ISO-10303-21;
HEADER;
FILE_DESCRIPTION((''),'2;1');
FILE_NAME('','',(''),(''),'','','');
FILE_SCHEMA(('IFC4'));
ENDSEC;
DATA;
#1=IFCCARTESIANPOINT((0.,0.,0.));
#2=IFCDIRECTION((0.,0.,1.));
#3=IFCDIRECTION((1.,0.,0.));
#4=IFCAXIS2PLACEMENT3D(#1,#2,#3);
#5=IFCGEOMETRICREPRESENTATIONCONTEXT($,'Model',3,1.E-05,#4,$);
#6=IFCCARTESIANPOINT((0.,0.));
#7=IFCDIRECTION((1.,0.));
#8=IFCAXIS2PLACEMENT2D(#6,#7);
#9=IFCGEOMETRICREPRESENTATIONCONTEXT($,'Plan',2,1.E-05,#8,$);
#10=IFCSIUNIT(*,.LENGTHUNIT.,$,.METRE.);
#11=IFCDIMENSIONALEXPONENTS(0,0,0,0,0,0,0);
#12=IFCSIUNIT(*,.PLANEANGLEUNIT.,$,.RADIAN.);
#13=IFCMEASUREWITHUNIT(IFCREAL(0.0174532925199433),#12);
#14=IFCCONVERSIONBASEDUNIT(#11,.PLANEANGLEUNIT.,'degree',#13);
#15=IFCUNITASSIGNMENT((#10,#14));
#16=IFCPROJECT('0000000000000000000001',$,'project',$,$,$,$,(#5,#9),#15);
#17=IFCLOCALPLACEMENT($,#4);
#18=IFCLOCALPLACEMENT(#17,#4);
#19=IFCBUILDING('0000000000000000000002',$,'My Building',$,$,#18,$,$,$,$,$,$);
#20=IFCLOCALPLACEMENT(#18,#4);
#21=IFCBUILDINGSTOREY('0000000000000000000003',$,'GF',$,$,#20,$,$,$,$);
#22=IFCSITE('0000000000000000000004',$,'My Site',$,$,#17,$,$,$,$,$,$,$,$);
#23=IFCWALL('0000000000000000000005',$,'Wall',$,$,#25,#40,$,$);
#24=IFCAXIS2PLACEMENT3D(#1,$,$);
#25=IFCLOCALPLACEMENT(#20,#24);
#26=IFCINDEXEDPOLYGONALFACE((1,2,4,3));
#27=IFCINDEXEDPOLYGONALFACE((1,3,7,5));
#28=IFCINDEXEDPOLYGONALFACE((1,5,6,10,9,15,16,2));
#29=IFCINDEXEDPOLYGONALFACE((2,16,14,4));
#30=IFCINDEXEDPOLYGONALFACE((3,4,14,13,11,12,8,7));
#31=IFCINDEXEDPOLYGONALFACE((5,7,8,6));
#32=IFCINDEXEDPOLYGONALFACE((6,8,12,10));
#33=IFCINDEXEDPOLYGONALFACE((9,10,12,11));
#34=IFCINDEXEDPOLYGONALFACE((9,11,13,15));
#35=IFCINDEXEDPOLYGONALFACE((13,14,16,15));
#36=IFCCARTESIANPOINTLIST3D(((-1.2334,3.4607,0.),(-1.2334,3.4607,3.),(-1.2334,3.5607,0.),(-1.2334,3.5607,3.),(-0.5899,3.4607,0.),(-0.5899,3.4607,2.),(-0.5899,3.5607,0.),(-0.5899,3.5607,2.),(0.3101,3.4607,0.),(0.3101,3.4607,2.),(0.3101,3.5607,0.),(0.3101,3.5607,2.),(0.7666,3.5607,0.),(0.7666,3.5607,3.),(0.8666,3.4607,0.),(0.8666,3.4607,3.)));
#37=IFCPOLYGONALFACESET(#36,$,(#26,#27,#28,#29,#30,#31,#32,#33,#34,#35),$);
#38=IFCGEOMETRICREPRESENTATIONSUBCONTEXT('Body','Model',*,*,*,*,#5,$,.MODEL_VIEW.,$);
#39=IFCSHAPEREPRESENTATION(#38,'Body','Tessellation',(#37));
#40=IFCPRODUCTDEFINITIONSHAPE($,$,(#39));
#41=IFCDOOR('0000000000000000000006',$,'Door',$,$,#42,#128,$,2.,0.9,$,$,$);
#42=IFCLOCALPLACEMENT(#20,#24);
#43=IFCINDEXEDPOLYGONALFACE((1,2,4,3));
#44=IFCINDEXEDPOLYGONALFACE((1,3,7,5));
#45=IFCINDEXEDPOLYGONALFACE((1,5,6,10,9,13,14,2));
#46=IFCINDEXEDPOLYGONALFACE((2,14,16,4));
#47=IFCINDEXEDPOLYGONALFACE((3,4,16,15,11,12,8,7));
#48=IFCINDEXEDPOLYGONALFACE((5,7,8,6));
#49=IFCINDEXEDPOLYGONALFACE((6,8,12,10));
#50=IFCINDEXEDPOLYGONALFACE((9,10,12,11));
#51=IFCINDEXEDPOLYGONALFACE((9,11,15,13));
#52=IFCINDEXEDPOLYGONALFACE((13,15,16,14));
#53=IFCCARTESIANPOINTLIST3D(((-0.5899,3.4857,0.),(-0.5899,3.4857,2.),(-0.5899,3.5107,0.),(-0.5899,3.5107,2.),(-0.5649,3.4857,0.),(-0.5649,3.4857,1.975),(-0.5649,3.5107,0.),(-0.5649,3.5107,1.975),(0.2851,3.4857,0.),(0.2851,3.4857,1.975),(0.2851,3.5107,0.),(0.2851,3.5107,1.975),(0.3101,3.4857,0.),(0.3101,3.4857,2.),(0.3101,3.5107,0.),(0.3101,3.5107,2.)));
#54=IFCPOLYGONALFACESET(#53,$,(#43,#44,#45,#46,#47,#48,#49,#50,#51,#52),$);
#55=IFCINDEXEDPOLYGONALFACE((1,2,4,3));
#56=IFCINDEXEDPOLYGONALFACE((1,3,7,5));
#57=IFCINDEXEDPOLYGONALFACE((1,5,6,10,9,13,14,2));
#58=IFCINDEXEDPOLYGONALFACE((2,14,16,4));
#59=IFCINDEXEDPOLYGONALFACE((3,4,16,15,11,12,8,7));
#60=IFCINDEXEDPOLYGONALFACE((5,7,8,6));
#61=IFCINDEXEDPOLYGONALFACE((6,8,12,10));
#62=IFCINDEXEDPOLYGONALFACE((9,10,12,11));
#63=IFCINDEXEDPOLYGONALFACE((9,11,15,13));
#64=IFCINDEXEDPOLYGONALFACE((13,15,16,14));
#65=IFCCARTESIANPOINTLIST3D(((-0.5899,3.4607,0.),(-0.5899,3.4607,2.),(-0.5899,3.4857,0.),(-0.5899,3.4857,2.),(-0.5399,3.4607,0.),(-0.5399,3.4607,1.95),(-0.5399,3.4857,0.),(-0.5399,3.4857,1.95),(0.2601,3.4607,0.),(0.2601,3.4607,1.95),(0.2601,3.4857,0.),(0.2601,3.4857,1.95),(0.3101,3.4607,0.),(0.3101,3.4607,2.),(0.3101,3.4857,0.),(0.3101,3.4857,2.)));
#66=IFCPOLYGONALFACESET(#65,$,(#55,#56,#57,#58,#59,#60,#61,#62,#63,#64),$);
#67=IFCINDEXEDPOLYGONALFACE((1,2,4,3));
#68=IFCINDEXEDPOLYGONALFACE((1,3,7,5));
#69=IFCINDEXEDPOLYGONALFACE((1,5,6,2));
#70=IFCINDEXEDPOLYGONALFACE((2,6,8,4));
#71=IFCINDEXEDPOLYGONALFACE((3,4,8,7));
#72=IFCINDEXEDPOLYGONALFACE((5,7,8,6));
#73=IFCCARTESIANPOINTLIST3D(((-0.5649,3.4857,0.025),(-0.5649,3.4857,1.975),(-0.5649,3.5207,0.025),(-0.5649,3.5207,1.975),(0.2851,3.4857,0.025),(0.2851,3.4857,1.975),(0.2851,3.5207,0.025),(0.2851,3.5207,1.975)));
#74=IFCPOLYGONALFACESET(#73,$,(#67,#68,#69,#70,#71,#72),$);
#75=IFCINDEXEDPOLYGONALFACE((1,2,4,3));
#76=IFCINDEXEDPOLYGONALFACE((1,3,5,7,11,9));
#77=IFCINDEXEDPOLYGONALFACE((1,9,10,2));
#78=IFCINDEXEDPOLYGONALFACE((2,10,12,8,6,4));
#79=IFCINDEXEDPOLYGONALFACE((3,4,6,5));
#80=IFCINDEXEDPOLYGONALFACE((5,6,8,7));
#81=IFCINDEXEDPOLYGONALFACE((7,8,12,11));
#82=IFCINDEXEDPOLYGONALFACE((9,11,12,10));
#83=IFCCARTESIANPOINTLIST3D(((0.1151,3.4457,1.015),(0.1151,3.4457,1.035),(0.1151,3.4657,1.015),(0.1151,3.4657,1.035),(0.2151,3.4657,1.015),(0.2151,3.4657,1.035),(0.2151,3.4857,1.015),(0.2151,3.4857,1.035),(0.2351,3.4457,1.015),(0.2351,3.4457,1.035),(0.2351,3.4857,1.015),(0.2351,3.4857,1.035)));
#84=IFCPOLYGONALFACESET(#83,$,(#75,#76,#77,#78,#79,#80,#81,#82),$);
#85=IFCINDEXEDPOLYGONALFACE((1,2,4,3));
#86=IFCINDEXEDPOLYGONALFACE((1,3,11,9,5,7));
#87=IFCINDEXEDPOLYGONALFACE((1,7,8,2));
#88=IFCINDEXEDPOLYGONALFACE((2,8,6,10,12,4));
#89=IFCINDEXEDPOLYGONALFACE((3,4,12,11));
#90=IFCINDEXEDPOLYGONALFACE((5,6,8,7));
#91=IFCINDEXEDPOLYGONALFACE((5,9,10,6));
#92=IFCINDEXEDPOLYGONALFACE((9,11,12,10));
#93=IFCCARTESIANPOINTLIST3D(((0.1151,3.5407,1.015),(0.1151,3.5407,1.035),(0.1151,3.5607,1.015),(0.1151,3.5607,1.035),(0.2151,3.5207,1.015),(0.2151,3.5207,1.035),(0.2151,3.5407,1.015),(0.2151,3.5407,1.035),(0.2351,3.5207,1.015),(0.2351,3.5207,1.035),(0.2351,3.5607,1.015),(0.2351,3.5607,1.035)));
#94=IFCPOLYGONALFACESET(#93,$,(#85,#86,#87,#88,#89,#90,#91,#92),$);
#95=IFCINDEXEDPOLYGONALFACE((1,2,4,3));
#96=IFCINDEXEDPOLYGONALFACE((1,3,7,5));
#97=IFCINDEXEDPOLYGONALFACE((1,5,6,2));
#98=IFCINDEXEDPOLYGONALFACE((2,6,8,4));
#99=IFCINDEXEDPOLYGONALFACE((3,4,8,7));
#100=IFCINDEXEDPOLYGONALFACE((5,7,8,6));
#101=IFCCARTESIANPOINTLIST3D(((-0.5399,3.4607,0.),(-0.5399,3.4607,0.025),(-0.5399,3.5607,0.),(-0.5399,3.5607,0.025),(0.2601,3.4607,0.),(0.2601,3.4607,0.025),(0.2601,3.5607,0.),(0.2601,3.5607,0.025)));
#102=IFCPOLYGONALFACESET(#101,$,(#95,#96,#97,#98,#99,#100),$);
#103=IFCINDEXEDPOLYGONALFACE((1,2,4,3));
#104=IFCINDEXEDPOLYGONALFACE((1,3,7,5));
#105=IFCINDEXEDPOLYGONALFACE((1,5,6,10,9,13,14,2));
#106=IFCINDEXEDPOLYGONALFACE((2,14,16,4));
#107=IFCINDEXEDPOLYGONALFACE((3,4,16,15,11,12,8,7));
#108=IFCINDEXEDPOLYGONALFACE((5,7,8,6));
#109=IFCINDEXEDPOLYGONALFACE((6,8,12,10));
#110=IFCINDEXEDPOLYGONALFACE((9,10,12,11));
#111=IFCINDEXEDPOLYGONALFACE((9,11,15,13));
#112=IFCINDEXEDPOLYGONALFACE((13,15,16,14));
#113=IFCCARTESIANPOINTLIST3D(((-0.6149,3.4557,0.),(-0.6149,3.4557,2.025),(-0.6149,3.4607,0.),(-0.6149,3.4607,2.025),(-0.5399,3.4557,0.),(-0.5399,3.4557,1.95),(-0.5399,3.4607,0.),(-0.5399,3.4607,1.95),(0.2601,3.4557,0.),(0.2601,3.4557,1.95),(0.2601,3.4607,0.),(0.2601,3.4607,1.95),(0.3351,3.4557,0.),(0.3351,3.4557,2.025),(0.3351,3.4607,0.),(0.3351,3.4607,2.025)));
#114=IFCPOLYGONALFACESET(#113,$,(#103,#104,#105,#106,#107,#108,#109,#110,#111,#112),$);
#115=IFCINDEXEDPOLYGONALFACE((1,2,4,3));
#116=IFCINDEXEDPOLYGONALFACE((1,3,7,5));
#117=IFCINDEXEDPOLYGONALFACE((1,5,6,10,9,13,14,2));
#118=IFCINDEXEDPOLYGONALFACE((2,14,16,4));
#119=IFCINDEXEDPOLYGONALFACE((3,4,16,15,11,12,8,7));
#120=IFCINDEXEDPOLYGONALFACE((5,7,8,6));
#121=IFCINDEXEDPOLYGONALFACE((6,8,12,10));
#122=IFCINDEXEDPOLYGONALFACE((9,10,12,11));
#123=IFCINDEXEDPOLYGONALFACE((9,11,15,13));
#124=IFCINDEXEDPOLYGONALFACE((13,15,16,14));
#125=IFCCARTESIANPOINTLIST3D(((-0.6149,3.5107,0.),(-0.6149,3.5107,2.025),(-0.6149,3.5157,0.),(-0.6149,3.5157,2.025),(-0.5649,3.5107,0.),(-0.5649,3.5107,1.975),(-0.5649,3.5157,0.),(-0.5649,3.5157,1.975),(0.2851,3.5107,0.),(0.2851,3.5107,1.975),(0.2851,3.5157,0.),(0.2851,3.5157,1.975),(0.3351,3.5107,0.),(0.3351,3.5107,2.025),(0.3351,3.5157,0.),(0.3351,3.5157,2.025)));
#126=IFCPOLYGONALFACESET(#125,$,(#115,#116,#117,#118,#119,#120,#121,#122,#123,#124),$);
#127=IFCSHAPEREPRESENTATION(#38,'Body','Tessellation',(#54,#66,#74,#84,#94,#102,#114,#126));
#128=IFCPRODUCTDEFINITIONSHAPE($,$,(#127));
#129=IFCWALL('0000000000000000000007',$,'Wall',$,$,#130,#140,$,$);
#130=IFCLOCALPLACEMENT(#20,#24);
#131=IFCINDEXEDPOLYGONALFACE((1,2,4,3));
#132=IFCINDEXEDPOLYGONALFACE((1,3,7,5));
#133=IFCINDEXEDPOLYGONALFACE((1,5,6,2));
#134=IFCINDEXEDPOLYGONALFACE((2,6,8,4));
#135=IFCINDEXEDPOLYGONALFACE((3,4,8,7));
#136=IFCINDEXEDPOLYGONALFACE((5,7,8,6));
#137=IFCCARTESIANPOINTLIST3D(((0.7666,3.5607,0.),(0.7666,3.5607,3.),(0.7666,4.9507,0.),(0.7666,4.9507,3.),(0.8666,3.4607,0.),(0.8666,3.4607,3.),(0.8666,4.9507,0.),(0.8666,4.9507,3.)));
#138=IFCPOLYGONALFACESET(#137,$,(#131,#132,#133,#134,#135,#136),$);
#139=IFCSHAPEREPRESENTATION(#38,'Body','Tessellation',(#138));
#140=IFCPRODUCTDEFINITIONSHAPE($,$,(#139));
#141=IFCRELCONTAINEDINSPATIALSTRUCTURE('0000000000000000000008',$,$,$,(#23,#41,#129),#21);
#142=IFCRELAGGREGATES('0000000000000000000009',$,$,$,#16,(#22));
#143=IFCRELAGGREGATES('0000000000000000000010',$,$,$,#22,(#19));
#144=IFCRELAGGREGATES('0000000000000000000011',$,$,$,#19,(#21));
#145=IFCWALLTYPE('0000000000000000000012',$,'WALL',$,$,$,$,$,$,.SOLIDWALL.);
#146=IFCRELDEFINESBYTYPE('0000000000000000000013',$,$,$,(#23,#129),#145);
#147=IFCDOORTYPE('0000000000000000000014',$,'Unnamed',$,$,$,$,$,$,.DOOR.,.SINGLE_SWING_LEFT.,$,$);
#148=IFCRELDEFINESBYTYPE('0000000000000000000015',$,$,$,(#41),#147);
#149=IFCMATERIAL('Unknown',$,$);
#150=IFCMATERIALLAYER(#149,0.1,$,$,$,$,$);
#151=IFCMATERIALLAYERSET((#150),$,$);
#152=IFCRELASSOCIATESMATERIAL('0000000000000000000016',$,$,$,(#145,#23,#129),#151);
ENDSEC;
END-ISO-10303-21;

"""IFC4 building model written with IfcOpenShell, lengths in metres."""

from ifc_helpers import new_model, entity, si_unit, converted_unit, frame, origin_with_axes, origin_2d_with_axis, place, context, subcontext, project, spatial, line, indexed_curve, outline, extrude, shape, source, transform, mapped, material, layer, layer_set, layer_usage, type_object, type_shapes, element, fill, save


model = new_model("IFC4")

# Units and contexts
model_context = context("Model", 3, precision=1e-05, world=origin_with_axes())
plan_context = context("Plan", 2, precision=1e-05, world=origin_2d_with_axis())
body_context_1 = subcontext(model_context, "Body", "Model", "MODEL_VIEW")
body_context_2 = subcontext(plan_context, "Body", "Plan", "PLAN_VIEW")
ifc_project = project(units=[si_unit("LENGTHUNIT", "METRE"), converted_unit("PLANEANGLEUNIT", "degree", entity("IfcReal", 0.0174532925199433), si_unit("PLANEANGLEUNIT", "RADIAN"), dimensions=[0, 0, 0, 0, 0, 0, 0])], contexts=[model_context, plan_context])

# Site, building, storey
site_placement = place(None, origin_with_axes())
site = spatial("IfcSite", under=ifc_project, at=site_placement, Name="My Site")
building_placement = place(site_placement, origin_with_axes())
building = spatial("IfcBuilding", under=site, at=building_placement, Name="My Building")
storey_placement = place(building_placement, origin_with_axes())
storey = spatial("IfcBuildingStorey", under=building, at=storey_placement, Name="GF")

# Shared definitions
ifc_material = material(Name="Unknown")

# Shared definitions
ifc_layer = layer(ifc_material, 0.1)
ifc_layer_set = layer_set([ifc_layer])
wall_type = type_object("IfcWallType", Name="WALL", PredefinedType="SOLIDWALL", material=ifc_layer_set)

# Wall, opening, door
ifc_layer_usage_1 = layer_usage(ifc_layer_set, "AXIS2", "POSITIVE", 0.0)
wall_1_placement = place(storey_placement, frame((-1.2334, 3.4607, 0.0), z_axis=(0.0, 0.0, 1.0), x_axis=(1.0, 0.0, 0.0)))
wall_1 = element("IfcWall", 1, at=wall_1_placement, inside=storey, type_object=wall_type, material=ifc_layer_usage_1, Name="Wall", context=body_context_1, shape_type="SweptSolid", body=[
    extrude(outline(indexed_curve([(0.0, 0.0), (0.0, 0.1), (2.0, 0.1), (2.1, 0.0)], segments=[line(1, 2, 3, 4, 1)])), origin_with_axes(), (0.0, 0.0, 1.0), 3.0),
])
shared_shape_1 = source(origin_with_axes(), body_context_1, "Body", "SweptSolid", [
    extrude(outline(indexed_curve([(0.0, 0.0), (0.9, 0.0), (0.9, 2.0), (0.0, 2.0)], segments=[line(1, 2, 3, 4, 1)])), frame((0.0, -0.6, 0.0), z_axis=(0.0, -1.0, 0.0), x_axis=(1.0, 0.0, 0.0)), (0.0, 0.0, -1.0), 1.2),
])
opening_1_placement = place(wall_1_placement, frame((0.6435, 0.0, 0.0), z_axis=(0.0, 0.0, 1.0), x_axis=(1.0, 0.0, 0.0)))
opening_1 = element("IfcOpeningElement", 2, at=opening_1_placement, cuts=wall_1, PredefinedType="OPENING", context=body_context_1, shape_type="MappedRepresentation", body=[
    mapped(shared_shape_1, transform((0.0, 0.0, 0.0), x_axis=(1.0, 0.0, 0.0), y_axis=(0.0, 1.0, 0.0), z_axis=(0.0, 0.0, 1.0), scale=1.0)),
])
door_type = type_object("IfcDoorType", Name="Unnamed", OperationType="SINGLE_SWING_LEFT", PredefinedType="DOOR")
shared_shape_2 = source(origin_with_axes(), body_context_1, "Body", "SweptSolid", [
    extrude(outline(indexed_curve([(0.0, 0.0), (0.0, 2.0), (0.9, 2.0), (0.9, 0.0), (0.875, 0.0), (0.875, 1.975), (0.025, 1.975), (0.025, 0.0)], segments=[line(1, 2, 3, 4, 5, 6, 7, 8, 1)])), frame((0.0, 0.025, 0.0), z_axis=(0.0, -1.0, 0.0), x_axis=(1.0, 0.0, 0.0)), (0.0, 0.0, -1.0), 0.025),
    extrude(outline(indexed_curve([(0.0, 0.0), (0.0, 2.0), (0.9, 2.0), (0.9, 0.0), (0.85, 0.0), (0.85, 1.95), (0.05, 1.95), (0.05, 0.0)], segments=[line(1, 2, 3, 4, 5, 6, 7, 8, 1)])), frame((0.0, 0.0, 0.0), z_axis=(0.0, -1.0, 0.0), x_axis=(1.0, 0.0, 0.0)), (0.0, 0.0, -1.0), 0.025),
    extrude(outline(indexed_curve([(0.0, 0.0), (0.85, 0.0), (0.85, 0.035), (0.0, 0.035)], segments=[line(1, 2, 3, 4, 1)])), frame((0.025, 0.025, 0.025), z_axis=(0.0, 0.0, 1.0), x_axis=(1.0, 0.0, 0.0)), (0.0, 0.0, 1.0), 1.95),
    extrude(outline(indexed_curve([(0.0, 0.0), (0.0, -0.04), (-0.12, -0.04), (-0.12, -0.02), (-0.02, -0.02), (-0.02, 0.0)], segments=[line(1, 2, 3, 4, 5, 6, 1)])), frame((0.825, 0.025, 1.015), z_axis=(0.0, 0.0, 1.0), x_axis=(1.0, 0.0, 0.0)), (0.0, 0.0, 1.0), 0.02),
    extrude(outline(indexed_curve([(0.0, 0.0), (0.0, 0.04), (-0.12, 0.04), (-0.12, 0.02), (-0.02, 0.02), (-0.02, 0.0)], segments=[line(1, 2, 3, 4, 5, 6, 1)])), frame((0.825, 0.06, 1.015), z_axis=(0.0, 0.0, 1.0), x_axis=(1.0, 0.0, 0.0)), (0.0, 0.0, 1.0), 0.02),
    extrude(outline(indexed_curve([(0.0, 0.0), (0.8, 0.0), (0.8, 0.1), (0.0, 0.1)], segments=[line(1, 2, 3, 4, 1)])), frame((0.05, 0.0, 0.0), z_axis=(0.0, 0.0, 1.0), x_axis=(1.0, 0.0, 0.0)), (0.0, 0.0, 1.0), 0.025),
    extrude(outline(indexed_curve([(0.0, 0.0), (0.0, 2.025), (0.95, 2.025), (0.95, 0.0), (0.875, 0.0), (0.875, 1.95), (0.075, 1.95), (0.075, 0.0)], segments=[line(1, 2, 3, 4, 5, 6, 7, 8, 1)])), frame((-0.025, -0.005, 0.0), z_axis=(0.0, -1.0, 0.0), x_axis=(1.0, 0.0, 0.0)), (0.0, 0.0, -1.0), 0.005),
    extrude(outline(indexed_curve([(0.0, 0.0), (0.0, 2.025), (0.95, 2.025), (0.95, 0.0), (0.9, 0.0), (0.9, 1.975), (0.05, 1.975), (0.05, 0.0)], segments=[line(1, 2, 3, 4, 5, 6, 7, 8, 1)])), frame((-0.025, 0.05, 0.0), z_axis=(0.0, -1.0, 0.0), x_axis=(1.0, 0.0, 0.0)), (0.0, 0.0, -1.0), 0.005),
])
shared_shape_3 = source(origin_with_axes(), body_context_2, "Body", "Curve2D", [
    entity("IfcIndexedPolyCurve", entity("IfcCartesianPointList2D", [[0.0, 0.0], [0.0, 0.05], [0.025, 0.05], [0.025, 0.025], [0.05, 0.025], [0.05, 0.0]]), [entity("IfcLineIndex", [1, 2, 3, 4, 5, 6, 1])]),
    entity("IfcIndexedPolyCurve", entity("IfcCartesianPointList2D", [[0.9, 0.0], [0.9, 0.05], [0.875, 0.05], [0.875, 0.025], [0.85, 0.025], [0.85, 0.0]]), [entity("IfcLineIndex", [1, 2, 3, 4, 5, 6, 1])]),
    entity("IfcTrimmedCurve", entity("IfcEllipse", entity("IfcAxis2Placement2D", entity("IfcCartesianPoint", [0.06, 0.05]), entity("IfcDirection", [1.0, 0.0])), 0.815, 0.85), [entity("IfcCartesianPoint", [0.875, 0.05])], [entity("IfcCartesianPoint", [0.06, 0.9])], True, "CARTESIAN"),
    entity("IfcIndexedPolyCurve", entity("IfcCartesianPointList2D", [[0.025, 0.05], [0.06, 0.05], [0.06, 0.9], [0.025, 0.9]]), [entity("IfcLineIndex", [1, 2, 3, 4, 1])]),
])
type_shapes(door_type, [shared_shape_2, shared_shape_3])
door_placement = place(opening_1_placement, origin_with_axes())
door = element("IfcDoor", 3, at=door_placement, inside=storey, type_object=door_type, Name="Door", OverallHeight=2.0, OverallWidth=0.9, shapes=[
    shape(body_context_1, "Body", "MappedRepresentation", [mapped(shared_shape_2, transform((0.0, 0.0, 0.0), x_axis=(1.0, 0.0, 0.0), y_axis=(0.0, 1.0, 0.0), z_axis=(0.0, 0.0, 1.0), scale=1.0))]),
    shape(body_context_2, "Body", "MappedRepresentation", [mapped(shared_shape_3, transform((0.0, 0.0, 0.0), x_axis=(1.0, 0.0, 0.0), y_axis=(0.0, 1.0, 0.0), z_axis=(0.0, 0.0, 1.0), scale=1.0))]),
])
fill(opening_1, door)

# Wall
ifc_layer_usage_2 = layer_usage(ifc_layer_set, "AXIS2", "POSITIVE", 0.0)
wall_2_placement = place(storey_placement, frame((0.8666, 3.4607, 0.0), z_axis=(0.0, 0.0, 1.0), x_axis=(0.0, 1.0, 0.0)))
element("IfcWall", 4, at=wall_2_placement, inside=storey, type_object=wall_type, material=ifc_layer_usage_2, Name="Wall", context=body_context_1, shape_type="SweptSolid", body=[
    extrude(outline(indexed_curve([(0.0, 0.0), (0.1, 0.1), (1.49, 0.1), (1.49, 0.0)], segments=[line(1, 2, 3, 4, 1)])), origin_with_axes(), (0.0, 0.0, 1.0), 3.0),
])

save(model, "model.ifc")
